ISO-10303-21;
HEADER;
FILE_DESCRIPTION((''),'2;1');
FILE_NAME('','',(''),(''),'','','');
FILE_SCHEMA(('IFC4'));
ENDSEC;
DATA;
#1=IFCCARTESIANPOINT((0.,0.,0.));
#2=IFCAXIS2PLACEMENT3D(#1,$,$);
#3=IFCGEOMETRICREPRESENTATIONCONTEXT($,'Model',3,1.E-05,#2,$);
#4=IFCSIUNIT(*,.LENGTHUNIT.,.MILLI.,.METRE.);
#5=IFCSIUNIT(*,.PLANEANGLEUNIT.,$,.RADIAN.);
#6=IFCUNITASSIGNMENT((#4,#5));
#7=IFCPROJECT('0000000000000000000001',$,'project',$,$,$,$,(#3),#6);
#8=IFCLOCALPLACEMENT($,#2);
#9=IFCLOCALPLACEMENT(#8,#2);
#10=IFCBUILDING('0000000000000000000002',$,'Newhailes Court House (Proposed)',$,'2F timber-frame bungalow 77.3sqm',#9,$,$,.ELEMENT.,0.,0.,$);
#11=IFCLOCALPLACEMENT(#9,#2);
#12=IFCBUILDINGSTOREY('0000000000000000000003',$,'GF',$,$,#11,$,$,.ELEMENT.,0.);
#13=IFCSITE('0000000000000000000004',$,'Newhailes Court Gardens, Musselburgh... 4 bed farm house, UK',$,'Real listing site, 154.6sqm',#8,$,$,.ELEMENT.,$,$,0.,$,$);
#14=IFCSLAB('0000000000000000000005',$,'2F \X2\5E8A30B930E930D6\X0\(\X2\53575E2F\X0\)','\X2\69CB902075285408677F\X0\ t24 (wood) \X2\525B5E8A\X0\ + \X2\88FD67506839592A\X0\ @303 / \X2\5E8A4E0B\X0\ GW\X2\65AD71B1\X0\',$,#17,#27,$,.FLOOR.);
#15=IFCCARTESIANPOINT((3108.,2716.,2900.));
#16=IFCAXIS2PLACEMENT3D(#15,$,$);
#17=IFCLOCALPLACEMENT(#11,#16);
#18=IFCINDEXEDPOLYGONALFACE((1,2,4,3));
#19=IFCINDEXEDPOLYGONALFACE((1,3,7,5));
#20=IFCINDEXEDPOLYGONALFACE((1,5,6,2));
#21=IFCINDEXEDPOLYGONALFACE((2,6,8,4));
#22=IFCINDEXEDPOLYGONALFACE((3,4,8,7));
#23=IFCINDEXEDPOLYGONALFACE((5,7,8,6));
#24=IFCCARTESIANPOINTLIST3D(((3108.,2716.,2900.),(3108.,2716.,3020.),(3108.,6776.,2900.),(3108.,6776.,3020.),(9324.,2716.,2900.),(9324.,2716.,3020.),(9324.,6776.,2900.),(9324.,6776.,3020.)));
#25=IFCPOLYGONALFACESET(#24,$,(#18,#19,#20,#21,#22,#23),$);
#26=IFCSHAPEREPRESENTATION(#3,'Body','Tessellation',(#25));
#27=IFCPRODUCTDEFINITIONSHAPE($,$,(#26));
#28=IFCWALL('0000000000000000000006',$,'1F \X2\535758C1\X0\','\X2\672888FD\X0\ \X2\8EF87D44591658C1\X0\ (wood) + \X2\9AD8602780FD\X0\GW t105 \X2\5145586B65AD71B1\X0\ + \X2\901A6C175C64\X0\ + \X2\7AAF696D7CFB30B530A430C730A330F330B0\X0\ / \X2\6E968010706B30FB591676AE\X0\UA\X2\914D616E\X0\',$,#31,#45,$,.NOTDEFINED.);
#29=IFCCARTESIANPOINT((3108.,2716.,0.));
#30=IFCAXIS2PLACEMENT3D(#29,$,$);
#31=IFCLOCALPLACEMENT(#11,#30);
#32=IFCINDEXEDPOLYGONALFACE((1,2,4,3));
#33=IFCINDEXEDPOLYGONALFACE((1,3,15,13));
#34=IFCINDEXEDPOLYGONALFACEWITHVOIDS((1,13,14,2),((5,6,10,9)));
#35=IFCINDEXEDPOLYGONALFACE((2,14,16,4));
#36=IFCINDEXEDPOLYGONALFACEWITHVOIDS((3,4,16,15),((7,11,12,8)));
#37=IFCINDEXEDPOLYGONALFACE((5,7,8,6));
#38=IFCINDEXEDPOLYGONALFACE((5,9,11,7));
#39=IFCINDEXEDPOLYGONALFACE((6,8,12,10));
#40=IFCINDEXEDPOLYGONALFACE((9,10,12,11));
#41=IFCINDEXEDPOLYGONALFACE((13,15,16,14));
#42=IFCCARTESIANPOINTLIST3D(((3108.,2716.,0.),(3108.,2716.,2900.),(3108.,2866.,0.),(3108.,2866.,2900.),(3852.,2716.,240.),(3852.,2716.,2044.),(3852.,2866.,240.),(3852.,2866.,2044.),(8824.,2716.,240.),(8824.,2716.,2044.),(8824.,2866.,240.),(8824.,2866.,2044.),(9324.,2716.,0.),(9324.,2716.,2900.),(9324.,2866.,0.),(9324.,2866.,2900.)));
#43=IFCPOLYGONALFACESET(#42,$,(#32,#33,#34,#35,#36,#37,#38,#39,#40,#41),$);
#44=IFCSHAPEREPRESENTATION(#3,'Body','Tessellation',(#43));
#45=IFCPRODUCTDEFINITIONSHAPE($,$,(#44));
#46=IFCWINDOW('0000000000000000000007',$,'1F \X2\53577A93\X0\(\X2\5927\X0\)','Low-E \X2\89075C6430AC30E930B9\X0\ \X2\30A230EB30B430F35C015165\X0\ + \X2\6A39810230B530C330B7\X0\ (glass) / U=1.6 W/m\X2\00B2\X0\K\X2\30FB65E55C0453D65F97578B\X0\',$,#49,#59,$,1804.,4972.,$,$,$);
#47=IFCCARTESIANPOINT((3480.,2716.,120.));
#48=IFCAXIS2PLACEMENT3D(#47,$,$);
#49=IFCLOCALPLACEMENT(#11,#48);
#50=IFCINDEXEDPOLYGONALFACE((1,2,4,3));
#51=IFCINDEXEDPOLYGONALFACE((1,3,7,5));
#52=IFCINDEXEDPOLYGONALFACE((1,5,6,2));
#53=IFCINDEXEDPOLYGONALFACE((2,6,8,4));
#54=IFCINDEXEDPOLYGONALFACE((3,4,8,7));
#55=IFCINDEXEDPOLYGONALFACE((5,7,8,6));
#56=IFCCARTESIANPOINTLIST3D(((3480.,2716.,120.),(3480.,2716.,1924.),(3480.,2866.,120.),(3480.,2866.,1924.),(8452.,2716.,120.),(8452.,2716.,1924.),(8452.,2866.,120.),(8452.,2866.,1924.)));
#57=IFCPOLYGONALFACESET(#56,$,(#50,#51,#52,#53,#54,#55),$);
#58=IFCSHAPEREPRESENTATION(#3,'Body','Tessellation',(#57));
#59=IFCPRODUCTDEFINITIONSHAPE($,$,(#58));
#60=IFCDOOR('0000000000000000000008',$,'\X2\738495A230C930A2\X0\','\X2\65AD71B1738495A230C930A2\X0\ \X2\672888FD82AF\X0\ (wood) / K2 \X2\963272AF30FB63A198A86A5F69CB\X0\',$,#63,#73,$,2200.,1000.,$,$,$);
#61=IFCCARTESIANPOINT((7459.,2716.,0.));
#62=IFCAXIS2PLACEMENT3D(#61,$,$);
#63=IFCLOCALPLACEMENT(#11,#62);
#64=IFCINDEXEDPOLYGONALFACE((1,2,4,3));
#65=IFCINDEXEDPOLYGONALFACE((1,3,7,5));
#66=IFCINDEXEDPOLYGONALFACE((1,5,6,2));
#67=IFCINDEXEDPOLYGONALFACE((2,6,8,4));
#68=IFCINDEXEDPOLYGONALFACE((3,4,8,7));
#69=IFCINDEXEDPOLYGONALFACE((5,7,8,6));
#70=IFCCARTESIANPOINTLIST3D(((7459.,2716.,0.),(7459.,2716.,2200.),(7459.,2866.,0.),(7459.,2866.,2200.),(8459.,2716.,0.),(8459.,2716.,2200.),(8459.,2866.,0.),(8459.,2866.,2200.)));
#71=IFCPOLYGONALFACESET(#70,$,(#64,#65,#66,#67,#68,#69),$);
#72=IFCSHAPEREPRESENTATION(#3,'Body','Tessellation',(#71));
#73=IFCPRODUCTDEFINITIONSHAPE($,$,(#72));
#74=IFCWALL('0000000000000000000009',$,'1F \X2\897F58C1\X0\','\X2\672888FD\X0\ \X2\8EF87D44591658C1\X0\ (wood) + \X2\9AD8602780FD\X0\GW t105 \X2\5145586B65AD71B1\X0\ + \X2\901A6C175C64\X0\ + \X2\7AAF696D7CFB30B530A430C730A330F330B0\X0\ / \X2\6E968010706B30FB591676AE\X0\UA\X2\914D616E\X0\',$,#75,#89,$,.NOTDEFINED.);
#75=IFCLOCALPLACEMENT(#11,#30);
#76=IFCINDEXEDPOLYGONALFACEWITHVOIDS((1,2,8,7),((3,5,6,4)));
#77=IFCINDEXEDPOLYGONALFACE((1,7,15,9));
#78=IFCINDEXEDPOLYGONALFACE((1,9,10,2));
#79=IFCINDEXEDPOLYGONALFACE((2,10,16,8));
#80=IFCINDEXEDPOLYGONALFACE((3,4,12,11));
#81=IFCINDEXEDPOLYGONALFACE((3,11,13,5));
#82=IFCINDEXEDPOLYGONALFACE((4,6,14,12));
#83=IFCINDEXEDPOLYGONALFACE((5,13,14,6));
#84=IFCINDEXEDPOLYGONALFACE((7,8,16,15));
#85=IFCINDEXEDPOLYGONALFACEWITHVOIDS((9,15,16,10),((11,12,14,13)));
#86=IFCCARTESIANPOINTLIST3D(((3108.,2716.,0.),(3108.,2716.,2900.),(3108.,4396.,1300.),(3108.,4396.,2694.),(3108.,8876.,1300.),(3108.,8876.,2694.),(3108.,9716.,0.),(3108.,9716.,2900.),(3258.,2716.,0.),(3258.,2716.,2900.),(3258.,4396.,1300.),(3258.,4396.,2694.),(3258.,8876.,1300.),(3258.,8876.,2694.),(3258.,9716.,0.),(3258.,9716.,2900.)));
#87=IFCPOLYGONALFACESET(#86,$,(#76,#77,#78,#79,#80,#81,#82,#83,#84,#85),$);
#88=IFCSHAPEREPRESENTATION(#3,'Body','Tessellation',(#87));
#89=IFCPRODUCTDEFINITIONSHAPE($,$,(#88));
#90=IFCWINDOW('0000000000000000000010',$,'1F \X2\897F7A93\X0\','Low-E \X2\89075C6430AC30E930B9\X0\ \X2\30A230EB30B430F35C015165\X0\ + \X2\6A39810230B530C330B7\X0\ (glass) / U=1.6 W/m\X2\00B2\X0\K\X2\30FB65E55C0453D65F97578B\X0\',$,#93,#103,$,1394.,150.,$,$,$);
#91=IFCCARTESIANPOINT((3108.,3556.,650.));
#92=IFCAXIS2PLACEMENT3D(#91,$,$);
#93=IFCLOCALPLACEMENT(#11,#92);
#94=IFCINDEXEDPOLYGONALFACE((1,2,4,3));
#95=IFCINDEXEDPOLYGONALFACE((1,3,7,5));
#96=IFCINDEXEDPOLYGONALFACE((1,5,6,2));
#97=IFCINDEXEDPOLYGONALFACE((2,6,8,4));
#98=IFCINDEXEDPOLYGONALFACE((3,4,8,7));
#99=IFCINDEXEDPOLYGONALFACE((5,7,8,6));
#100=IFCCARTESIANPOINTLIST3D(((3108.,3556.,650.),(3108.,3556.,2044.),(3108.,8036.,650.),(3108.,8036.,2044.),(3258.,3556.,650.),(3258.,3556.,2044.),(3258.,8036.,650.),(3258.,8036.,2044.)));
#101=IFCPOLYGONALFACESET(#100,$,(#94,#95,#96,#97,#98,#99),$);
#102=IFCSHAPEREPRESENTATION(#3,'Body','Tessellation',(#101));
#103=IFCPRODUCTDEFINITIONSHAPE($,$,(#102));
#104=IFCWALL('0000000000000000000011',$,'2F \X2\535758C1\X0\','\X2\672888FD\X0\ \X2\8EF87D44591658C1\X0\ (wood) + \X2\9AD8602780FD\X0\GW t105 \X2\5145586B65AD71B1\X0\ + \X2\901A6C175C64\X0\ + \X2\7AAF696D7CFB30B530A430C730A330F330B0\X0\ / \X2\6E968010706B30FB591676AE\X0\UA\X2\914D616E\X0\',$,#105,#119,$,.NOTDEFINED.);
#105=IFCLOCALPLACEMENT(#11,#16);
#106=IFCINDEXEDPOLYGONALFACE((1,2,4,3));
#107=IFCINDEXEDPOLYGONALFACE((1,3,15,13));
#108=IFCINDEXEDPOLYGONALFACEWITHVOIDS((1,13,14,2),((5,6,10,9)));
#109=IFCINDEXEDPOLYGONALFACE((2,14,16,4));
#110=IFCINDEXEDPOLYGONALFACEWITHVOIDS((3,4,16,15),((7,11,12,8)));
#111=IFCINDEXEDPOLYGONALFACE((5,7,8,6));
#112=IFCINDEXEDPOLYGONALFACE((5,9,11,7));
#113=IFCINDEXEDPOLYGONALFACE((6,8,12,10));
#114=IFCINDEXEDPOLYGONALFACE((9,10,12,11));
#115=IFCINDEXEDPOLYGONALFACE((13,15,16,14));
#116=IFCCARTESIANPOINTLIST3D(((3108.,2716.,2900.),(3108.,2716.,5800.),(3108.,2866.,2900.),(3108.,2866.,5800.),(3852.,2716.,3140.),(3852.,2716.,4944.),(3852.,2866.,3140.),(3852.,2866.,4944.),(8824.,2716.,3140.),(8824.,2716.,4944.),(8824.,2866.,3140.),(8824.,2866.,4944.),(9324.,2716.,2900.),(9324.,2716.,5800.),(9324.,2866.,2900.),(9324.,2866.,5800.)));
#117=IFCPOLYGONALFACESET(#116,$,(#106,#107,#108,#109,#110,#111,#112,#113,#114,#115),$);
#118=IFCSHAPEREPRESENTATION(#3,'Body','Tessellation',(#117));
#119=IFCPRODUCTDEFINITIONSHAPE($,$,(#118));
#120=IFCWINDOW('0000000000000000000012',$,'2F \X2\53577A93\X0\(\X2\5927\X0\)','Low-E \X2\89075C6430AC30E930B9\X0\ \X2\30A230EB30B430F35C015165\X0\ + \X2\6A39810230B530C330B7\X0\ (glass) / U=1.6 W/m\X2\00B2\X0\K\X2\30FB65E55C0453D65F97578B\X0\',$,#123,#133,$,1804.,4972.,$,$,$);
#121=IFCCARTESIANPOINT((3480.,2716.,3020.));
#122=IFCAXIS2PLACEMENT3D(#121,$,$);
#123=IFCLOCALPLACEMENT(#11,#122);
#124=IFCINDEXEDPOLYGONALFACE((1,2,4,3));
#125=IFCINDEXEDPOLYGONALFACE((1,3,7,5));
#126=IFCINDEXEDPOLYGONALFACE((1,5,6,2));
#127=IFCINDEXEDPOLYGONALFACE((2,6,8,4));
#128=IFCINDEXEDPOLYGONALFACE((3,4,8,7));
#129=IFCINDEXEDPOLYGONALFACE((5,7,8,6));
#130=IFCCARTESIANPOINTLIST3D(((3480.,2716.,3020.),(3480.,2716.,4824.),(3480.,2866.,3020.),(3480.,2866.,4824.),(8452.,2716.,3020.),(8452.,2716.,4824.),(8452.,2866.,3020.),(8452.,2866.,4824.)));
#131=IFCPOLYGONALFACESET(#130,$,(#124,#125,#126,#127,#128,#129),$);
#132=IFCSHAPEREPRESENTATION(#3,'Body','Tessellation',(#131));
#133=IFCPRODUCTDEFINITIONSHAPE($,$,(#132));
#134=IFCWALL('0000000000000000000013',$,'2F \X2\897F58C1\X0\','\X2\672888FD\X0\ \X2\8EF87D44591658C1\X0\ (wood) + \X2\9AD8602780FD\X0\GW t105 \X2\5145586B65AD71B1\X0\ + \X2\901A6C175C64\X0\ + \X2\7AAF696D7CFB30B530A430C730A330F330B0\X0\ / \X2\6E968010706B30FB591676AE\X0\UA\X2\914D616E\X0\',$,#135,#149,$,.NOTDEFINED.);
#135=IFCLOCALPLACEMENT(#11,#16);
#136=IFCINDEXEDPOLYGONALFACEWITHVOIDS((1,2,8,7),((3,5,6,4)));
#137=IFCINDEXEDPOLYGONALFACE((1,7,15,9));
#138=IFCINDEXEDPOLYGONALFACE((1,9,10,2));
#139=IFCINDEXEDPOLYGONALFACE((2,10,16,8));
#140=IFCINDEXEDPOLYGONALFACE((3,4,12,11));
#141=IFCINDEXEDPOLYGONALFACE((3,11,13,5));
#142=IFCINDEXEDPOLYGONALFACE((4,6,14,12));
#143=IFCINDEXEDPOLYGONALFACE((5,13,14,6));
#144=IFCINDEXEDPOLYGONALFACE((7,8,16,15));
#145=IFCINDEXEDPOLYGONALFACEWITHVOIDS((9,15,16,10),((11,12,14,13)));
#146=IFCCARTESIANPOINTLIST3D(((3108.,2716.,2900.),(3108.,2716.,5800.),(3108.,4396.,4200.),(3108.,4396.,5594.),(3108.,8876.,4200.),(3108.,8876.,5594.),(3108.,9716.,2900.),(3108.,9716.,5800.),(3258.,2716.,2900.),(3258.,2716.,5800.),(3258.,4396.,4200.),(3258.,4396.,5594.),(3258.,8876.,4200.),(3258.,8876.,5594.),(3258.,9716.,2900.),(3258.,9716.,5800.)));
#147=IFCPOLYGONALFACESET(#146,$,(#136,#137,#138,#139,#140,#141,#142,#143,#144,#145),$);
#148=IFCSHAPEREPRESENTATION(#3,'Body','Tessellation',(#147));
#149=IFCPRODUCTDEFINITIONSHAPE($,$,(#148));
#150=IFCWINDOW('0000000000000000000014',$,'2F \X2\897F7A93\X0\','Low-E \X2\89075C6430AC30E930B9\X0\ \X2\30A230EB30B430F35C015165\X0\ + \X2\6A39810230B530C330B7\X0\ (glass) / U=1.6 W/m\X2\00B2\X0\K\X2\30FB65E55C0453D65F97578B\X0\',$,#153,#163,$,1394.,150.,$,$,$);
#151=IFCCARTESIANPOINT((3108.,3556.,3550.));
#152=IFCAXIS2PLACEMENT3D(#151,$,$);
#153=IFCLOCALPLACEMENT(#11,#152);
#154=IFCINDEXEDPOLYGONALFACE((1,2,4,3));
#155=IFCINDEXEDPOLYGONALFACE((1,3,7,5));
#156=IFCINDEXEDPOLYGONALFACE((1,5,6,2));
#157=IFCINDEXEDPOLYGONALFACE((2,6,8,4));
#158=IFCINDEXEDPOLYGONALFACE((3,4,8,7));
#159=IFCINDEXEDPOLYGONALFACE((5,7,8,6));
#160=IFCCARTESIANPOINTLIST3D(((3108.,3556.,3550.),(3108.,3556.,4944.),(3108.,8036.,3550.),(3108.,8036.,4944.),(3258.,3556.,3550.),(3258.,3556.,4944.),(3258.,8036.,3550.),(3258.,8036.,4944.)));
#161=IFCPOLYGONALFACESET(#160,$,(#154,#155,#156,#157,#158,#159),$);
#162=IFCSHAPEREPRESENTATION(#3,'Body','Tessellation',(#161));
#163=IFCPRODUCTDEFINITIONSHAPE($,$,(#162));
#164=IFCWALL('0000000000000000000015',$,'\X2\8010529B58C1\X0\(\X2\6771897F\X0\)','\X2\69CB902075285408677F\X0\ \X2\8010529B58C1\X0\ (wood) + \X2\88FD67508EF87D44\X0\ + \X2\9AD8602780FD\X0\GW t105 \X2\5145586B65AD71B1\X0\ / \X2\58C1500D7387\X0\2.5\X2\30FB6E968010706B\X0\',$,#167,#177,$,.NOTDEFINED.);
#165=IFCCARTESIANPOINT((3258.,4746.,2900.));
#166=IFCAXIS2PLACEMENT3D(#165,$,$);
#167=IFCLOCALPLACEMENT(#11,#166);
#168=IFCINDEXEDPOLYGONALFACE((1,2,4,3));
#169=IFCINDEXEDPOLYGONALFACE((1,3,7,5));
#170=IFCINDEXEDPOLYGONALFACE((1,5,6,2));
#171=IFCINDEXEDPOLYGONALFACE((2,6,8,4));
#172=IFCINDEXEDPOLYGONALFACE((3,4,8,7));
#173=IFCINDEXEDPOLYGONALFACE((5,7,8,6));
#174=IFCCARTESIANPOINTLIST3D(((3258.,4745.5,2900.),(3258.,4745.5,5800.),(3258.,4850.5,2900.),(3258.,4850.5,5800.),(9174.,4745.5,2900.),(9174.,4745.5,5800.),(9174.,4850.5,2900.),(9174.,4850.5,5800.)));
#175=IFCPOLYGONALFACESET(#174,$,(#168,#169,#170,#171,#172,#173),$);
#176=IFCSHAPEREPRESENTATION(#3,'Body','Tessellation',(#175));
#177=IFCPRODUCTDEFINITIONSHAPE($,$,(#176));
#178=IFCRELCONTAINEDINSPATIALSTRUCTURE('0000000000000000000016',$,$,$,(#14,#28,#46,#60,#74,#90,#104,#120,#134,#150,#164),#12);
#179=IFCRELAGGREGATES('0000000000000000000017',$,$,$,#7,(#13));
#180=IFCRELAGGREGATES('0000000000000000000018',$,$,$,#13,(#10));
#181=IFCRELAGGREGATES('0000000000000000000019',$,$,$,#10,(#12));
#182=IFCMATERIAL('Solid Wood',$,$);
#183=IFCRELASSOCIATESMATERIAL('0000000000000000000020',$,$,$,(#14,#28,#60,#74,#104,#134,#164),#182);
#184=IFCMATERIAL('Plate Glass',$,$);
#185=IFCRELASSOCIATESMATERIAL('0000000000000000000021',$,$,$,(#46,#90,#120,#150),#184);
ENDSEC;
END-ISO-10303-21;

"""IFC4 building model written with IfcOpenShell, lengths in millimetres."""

from ifc_helpers import new_model, si_unit, frame, frame_2d, origin, place, context, project, spatial, rectangle, extrude, material, element, fill, save


model = new_model("IFC4")

# Units and contexts
model_context = context("Model", 3, precision=1e-05, world=origin())
ifc_project = project(units=[si_unit("LENGTHUNIT", "METRE", prefix="MILLI"), si_unit("PLANEANGLEUNIT", "RADIAN")], contexts=[model_context])

# Site, building, storey
site_placement = place(None, origin())
site = spatial("IfcSite", under=ifc_project, at=site_placement, Name="Newhailes Court Gardens, Musselburgh... 4 bed farm house, UK", ObjectType="Real listing site, 154.6sqm", CompositionType="ELEMENT", RefElevation=0.0)
building_placement = place(site_placement, origin())
building = spatial("IfcBuilding", under=site, at=building_placement, Name="Newhailes Court House (Proposed)", ObjectType="2F timber-frame bungalow 77.3sqm", CompositionType="ELEMENT", ElevationOfRefHeight=0.0, ElevationOfTerrain=0.0)
storey_placement = place(building_placement, origin())
storey = spatial("IfcBuildingStorey", under=building, at=storey_placement, Name="GF", CompositionType="ELEMENT", Elevation=0.0)

# Slab
ifc_material_1 = material(Name="Solid Wood")
slab_1_placement = place(storey_placement, frame((3108.0, 2716.0, 2900.0)))
element("IfcSlab", 1, at=slab_1_placement, inside=storey, material=ifc_material_1, Name="2F 床スラブ(南帯)", Description="構造用合板 t24 (wood) 剛床 + 製材根太 @303 / 床下 GW断熱", PredefinedType="FLOOR", context=model_context, shape_type="SweptSolid", body=[
    extrude(rectangle(XDim=6216.0, YDim=4060.0, at=frame_2d((3108.0, 2030.0))), frame((3108.0, 2716.0, 2900.0)), (0.0, 0.0, 1.0), 120.0),
])

# Wall, openings, window, door
wall_1_placement = place(storey_placement, frame((3108.0, 2716.0, 0.0)))
wall_1 = element("IfcWall", 2, at=wall_1_placement, inside=storey, material=ifc_material_1, Name="1F 南壁", Description="木製 軸組外壁 (wood) + 高性能GW t105 充填断熱 + 通気層 + 窯業系サイディング / 準耐火・外皮UA配慮", PredefinedType="NOTDEFINED", context=model_context, shape_type="SweptSolid", body=[
    extrude(rectangle(XDim=6216.0, YDim=150.0, at=frame_2d((3108.0, 75.0))), frame((3108.0, 2716.0, 0.0)), (0.0, 0.0, 1.0), 2900.0),
])
opening_1_placement = place(storey_placement, frame((3480.0, 2716.0, 120.0)))
opening_1 = element("IfcOpeningElement", 3, at=opening_1_placement, cuts=wall_1, PredefinedType="NOTDEFINED", context=model_context, shape_type="SweptSolid", body=[
    extrude(rectangle(XDim=4972.0, YDim=150.0, at=frame_2d((2486.0, 75.0))), frame((3480.0, 2716.0, 120.0)), (0.0, 0.0, 1.0), 1804.0),
])
opening_2_placement = place(storey_placement, frame((7459.0, 2716.0, 0.0)))
opening_2 = element("IfcOpeningElement", 4, at=opening_2_placement, cuts=wall_1, PredefinedType="NOTDEFINED", context=model_context, shape_type="SweptSolid", body=[
    extrude(rectangle(XDim=1000.0, YDim=150.0, at=frame_2d((500.0, 75.0))), frame((7459.0, 2716.0, 0.0)), (0.0, 0.0, 1.0), 2200.0),
])
ifc_material_2 = material(Name="Plate Glass")
window_1_placement = place(storey_placement, frame((3480.0, 2716.0, 120.0)))
window_1 = element("IfcWindow", 5, at=window_1_placement, inside=storey, material=ifc_material_2, Name="1F 南窓(大)", Description="Low-E 複層ガラス アルゴン封入 + 樹脂サッシ (glass) / U=1.6 W/m²K・日射取得型", OverallHeight=1804.0, OverallWidth=4972.0, context=model_context, shape_type="SweptSolid", body=[
    extrude(rectangle(XDim=4972.0, YDim=150.0, at=frame_2d((2486.0, 75.0))), frame((3480.0, 2716.0, 120.0)), (0.0, 0.0, 1.0), 1804.0),
])
fill(opening_1, window_1)
door_placement = place(storey_placement, frame((7459.0, 2716.0, 0.0)))
door = element("IfcDoor", 6, at=door_placement, inside=storey, material=ifc_material_1, Name="玄関ドア", Description="断熱玄関ドア 木製芯 (wood) / K2 防犯・採風機構", OverallHeight=2200.0, OverallWidth=1000.0, context=model_context, shape_type="SweptSolid", body=[
    extrude(rectangle(XDim=1000.0, YDim=150.0, at=frame_2d((500.0, 75.0))), frame((7459.0, 2716.0, 0.0)), (0.0, 0.0, 1.0), 2200.0),
])
fill(opening_2, door)

# Wall, opening, window
wall_2_placement = place(storey_placement, frame((3108.0, 2716.0, 0.0)))
wall_2 = element("IfcWall", 7, at=wall_2_placement, inside=storey, material=ifc_material_1, Name="1F 西壁", Description="木製 軸組外壁 (wood) + 高性能GW t105 充填断熱 + 通気層 + 窯業系サイディング / 準耐火・外皮UA配慮", PredefinedType="NOTDEFINED", context=model_context, shape_type="SweptSolid", body=[
    extrude(rectangle(XDim=150.0, YDim=7000.0, at=frame_2d((75.0, 3500.0))), frame((3108.0, 2716.0, 0.0)), (0.0, 0.0, 1.0), 2900.0),
])
opening_3_placement = place(storey_placement, frame((3108.0, 3556.0, 650.0)))
opening_3 = element("IfcOpeningElement", 8, at=opening_3_placement, cuts=wall_2, PredefinedType="NOTDEFINED", context=model_context, shape_type="SweptSolid", body=[
    extrude(rectangle(XDim=150.0, YDim=4480.0, at=frame_2d((75.0, 2240.0))), frame((3108.0, 3556.0, 650.0)), (0.0, 0.0, 1.0), 1394.0),
])
window_2_placement = place(storey_placement, frame((3108.0, 3556.0, 650.0)))
window_2 = element("IfcWindow", 9, at=window_2_placement, inside=storey, material=ifc_material_2, Name="1F 西窓", Description="Low-E 複層ガラス アルゴン封入 + 樹脂サッシ (glass) / U=1.6 W/m²K・日射取得型", OverallHeight=1394.0, OverallWidth=150.0, context=model_context, shape_type="SweptSolid", body=[
    extrude(rectangle(XDim=150.0, YDim=4480.0, at=frame_2d((75.0, 2240.0))), frame((3108.0, 3556.0, 650.0)), (0.0, 0.0, 1.0), 1394.0),
])
fill(opening_3, window_2)

# Walls, openings, windows
wall_3_placement = place(storey_placement, frame((3108.0, 2716.0, 2900.0)))
wall_3 = element("IfcWall", 10, at=wall_3_placement, inside=storey, material=ifc_material_1, Name="2F 南壁", Description="木製 軸組外壁 (wood) + 高性能GW t105 充填断熱 + 通気層 + 窯業系サイディング / 準耐火・外皮UA配慮", PredefinedType="NOTDEFINED", context=model_context, shape_type="SweptSolid", body=[
    extrude(rectangle(XDim=6216.0, YDim=150.0, at=frame_2d((3108.0, 75.0))), frame((3108.0, 2716.0, 2900.0)), (0.0, 0.0, 1.0), 2900.0),
])
opening_4_placement = place(storey_placement, frame((3480.0, 2716.0, 3020.0)))
opening_4 = element("IfcOpeningElement", 11, at=opening_4_placement, cuts=wall_3, PredefinedType="NOTDEFINED", context=model_context, shape_type="SweptSolid", body=[
    extrude(rectangle(XDim=4972.0, YDim=150.0, at=frame_2d((2486.0, 75.0))), frame((3480.0, 2716.0, 3020.0)), (0.0, 0.0, 1.0), 1804.0),
])
window_3_placement = place(storey_placement, frame((3480.0, 2716.0, 3020.0)))
window_3 = element("IfcWindow", 12, at=window_3_placement, inside=storey, material=ifc_material_2, Name="2F 南窓(大)", Description="Low-E 複層ガラス アルゴン封入 + 樹脂サッシ (glass) / U=1.6 W/m²K・日射取得型", OverallHeight=1804.0, OverallWidth=4972.0, context=model_context, shape_type="SweptSolid", body=[
    extrude(rectangle(XDim=4972.0, YDim=150.0, at=frame_2d((2486.0, 75.0))), frame((3480.0, 2716.0, 3020.0)), (0.0, 0.0, 1.0), 1804.0),
])
fill(opening_4, window_3)
wall_4_placement = place(storey_placement, frame((3108.0, 2716.0, 2900.0)))
wall_4 = element("IfcWall", 13, at=wall_4_placement, inside=storey, material=ifc_material_1, Name="2F 西壁", Description="木製 軸組外壁 (wood) + 高性能GW t105 充填断熱 + 通気層 + 窯業系サイディング / 準耐火・外皮UA配慮", PredefinedType="NOTDEFINED", context=model_context, shape_type="SweptSolid", body=[
    extrude(rectangle(XDim=150.0, YDim=7000.0, at=frame_2d((75.0, 3500.0))), frame((3108.0, 2716.0, 2900.0)), (0.0, 0.0, 1.0), 2900.0),
])
opening_5_placement = place(storey_placement, frame((3108.0, 3556.0, 3550.0)))
opening_5 = element("IfcOpeningElement", 14, at=opening_5_placement, cuts=wall_4, PredefinedType="NOTDEFINED", context=model_context, shape_type="SweptSolid", body=[
    extrude(rectangle(XDim=150.0, YDim=4480.0, at=frame_2d((75.0, 2240.0))), frame((3108.0, 3556.0, 3550.0)), (0.0, 0.0, 1.0), 1394.0),
])
window_4_placement = place(storey_placement, frame((3108.0, 3556.0, 3550.0)))
window_4 = element("IfcWindow", 15, at=window_4_placement, inside=storey, material=ifc_material_2, Name="2F 西窓", Description="Low-E 複層ガラス アルゴン封入 + 樹脂サッシ (glass) / U=1.6 W/m²K・日射取得型", OverallHeight=1394.0, OverallWidth=150.0, context=model_context, shape_type="SweptSolid", body=[
    extrude(rectangle(XDim=150.0, YDim=4480.0, at=frame_2d((75.0, 2240.0))), frame((3108.0, 3556.0, 3550.0)), (0.0, 0.0, 1.0), 1394.0),
])
fill(opening_5, window_4)

# Wall
wall_5_placement = place(storey_placement, frame((3258.0, 4746.0, 2900.0)))
element("IfcWall", 16, at=wall_5_placement, inside=storey, material=ifc_material_1, Name="耐力壁(東西)", Description="構造用合板 耐力壁 (wood) + 製材軸組 + 高性能GW t105 充填断熱 / 壁倍率2.5・準耐火", PredefinedType="NOTDEFINED", context=model_context, shape_type="SweptSolid", body=[
    extrude(rectangle(XDim=5916.0, YDim=105.0, at=frame_2d((2958.0, 52.0))), frame((3258.0, 4746.0, 2900.0)), (0.0, 0.0, 1.0), 2900.0),
])

save(model, "model.ifc")
